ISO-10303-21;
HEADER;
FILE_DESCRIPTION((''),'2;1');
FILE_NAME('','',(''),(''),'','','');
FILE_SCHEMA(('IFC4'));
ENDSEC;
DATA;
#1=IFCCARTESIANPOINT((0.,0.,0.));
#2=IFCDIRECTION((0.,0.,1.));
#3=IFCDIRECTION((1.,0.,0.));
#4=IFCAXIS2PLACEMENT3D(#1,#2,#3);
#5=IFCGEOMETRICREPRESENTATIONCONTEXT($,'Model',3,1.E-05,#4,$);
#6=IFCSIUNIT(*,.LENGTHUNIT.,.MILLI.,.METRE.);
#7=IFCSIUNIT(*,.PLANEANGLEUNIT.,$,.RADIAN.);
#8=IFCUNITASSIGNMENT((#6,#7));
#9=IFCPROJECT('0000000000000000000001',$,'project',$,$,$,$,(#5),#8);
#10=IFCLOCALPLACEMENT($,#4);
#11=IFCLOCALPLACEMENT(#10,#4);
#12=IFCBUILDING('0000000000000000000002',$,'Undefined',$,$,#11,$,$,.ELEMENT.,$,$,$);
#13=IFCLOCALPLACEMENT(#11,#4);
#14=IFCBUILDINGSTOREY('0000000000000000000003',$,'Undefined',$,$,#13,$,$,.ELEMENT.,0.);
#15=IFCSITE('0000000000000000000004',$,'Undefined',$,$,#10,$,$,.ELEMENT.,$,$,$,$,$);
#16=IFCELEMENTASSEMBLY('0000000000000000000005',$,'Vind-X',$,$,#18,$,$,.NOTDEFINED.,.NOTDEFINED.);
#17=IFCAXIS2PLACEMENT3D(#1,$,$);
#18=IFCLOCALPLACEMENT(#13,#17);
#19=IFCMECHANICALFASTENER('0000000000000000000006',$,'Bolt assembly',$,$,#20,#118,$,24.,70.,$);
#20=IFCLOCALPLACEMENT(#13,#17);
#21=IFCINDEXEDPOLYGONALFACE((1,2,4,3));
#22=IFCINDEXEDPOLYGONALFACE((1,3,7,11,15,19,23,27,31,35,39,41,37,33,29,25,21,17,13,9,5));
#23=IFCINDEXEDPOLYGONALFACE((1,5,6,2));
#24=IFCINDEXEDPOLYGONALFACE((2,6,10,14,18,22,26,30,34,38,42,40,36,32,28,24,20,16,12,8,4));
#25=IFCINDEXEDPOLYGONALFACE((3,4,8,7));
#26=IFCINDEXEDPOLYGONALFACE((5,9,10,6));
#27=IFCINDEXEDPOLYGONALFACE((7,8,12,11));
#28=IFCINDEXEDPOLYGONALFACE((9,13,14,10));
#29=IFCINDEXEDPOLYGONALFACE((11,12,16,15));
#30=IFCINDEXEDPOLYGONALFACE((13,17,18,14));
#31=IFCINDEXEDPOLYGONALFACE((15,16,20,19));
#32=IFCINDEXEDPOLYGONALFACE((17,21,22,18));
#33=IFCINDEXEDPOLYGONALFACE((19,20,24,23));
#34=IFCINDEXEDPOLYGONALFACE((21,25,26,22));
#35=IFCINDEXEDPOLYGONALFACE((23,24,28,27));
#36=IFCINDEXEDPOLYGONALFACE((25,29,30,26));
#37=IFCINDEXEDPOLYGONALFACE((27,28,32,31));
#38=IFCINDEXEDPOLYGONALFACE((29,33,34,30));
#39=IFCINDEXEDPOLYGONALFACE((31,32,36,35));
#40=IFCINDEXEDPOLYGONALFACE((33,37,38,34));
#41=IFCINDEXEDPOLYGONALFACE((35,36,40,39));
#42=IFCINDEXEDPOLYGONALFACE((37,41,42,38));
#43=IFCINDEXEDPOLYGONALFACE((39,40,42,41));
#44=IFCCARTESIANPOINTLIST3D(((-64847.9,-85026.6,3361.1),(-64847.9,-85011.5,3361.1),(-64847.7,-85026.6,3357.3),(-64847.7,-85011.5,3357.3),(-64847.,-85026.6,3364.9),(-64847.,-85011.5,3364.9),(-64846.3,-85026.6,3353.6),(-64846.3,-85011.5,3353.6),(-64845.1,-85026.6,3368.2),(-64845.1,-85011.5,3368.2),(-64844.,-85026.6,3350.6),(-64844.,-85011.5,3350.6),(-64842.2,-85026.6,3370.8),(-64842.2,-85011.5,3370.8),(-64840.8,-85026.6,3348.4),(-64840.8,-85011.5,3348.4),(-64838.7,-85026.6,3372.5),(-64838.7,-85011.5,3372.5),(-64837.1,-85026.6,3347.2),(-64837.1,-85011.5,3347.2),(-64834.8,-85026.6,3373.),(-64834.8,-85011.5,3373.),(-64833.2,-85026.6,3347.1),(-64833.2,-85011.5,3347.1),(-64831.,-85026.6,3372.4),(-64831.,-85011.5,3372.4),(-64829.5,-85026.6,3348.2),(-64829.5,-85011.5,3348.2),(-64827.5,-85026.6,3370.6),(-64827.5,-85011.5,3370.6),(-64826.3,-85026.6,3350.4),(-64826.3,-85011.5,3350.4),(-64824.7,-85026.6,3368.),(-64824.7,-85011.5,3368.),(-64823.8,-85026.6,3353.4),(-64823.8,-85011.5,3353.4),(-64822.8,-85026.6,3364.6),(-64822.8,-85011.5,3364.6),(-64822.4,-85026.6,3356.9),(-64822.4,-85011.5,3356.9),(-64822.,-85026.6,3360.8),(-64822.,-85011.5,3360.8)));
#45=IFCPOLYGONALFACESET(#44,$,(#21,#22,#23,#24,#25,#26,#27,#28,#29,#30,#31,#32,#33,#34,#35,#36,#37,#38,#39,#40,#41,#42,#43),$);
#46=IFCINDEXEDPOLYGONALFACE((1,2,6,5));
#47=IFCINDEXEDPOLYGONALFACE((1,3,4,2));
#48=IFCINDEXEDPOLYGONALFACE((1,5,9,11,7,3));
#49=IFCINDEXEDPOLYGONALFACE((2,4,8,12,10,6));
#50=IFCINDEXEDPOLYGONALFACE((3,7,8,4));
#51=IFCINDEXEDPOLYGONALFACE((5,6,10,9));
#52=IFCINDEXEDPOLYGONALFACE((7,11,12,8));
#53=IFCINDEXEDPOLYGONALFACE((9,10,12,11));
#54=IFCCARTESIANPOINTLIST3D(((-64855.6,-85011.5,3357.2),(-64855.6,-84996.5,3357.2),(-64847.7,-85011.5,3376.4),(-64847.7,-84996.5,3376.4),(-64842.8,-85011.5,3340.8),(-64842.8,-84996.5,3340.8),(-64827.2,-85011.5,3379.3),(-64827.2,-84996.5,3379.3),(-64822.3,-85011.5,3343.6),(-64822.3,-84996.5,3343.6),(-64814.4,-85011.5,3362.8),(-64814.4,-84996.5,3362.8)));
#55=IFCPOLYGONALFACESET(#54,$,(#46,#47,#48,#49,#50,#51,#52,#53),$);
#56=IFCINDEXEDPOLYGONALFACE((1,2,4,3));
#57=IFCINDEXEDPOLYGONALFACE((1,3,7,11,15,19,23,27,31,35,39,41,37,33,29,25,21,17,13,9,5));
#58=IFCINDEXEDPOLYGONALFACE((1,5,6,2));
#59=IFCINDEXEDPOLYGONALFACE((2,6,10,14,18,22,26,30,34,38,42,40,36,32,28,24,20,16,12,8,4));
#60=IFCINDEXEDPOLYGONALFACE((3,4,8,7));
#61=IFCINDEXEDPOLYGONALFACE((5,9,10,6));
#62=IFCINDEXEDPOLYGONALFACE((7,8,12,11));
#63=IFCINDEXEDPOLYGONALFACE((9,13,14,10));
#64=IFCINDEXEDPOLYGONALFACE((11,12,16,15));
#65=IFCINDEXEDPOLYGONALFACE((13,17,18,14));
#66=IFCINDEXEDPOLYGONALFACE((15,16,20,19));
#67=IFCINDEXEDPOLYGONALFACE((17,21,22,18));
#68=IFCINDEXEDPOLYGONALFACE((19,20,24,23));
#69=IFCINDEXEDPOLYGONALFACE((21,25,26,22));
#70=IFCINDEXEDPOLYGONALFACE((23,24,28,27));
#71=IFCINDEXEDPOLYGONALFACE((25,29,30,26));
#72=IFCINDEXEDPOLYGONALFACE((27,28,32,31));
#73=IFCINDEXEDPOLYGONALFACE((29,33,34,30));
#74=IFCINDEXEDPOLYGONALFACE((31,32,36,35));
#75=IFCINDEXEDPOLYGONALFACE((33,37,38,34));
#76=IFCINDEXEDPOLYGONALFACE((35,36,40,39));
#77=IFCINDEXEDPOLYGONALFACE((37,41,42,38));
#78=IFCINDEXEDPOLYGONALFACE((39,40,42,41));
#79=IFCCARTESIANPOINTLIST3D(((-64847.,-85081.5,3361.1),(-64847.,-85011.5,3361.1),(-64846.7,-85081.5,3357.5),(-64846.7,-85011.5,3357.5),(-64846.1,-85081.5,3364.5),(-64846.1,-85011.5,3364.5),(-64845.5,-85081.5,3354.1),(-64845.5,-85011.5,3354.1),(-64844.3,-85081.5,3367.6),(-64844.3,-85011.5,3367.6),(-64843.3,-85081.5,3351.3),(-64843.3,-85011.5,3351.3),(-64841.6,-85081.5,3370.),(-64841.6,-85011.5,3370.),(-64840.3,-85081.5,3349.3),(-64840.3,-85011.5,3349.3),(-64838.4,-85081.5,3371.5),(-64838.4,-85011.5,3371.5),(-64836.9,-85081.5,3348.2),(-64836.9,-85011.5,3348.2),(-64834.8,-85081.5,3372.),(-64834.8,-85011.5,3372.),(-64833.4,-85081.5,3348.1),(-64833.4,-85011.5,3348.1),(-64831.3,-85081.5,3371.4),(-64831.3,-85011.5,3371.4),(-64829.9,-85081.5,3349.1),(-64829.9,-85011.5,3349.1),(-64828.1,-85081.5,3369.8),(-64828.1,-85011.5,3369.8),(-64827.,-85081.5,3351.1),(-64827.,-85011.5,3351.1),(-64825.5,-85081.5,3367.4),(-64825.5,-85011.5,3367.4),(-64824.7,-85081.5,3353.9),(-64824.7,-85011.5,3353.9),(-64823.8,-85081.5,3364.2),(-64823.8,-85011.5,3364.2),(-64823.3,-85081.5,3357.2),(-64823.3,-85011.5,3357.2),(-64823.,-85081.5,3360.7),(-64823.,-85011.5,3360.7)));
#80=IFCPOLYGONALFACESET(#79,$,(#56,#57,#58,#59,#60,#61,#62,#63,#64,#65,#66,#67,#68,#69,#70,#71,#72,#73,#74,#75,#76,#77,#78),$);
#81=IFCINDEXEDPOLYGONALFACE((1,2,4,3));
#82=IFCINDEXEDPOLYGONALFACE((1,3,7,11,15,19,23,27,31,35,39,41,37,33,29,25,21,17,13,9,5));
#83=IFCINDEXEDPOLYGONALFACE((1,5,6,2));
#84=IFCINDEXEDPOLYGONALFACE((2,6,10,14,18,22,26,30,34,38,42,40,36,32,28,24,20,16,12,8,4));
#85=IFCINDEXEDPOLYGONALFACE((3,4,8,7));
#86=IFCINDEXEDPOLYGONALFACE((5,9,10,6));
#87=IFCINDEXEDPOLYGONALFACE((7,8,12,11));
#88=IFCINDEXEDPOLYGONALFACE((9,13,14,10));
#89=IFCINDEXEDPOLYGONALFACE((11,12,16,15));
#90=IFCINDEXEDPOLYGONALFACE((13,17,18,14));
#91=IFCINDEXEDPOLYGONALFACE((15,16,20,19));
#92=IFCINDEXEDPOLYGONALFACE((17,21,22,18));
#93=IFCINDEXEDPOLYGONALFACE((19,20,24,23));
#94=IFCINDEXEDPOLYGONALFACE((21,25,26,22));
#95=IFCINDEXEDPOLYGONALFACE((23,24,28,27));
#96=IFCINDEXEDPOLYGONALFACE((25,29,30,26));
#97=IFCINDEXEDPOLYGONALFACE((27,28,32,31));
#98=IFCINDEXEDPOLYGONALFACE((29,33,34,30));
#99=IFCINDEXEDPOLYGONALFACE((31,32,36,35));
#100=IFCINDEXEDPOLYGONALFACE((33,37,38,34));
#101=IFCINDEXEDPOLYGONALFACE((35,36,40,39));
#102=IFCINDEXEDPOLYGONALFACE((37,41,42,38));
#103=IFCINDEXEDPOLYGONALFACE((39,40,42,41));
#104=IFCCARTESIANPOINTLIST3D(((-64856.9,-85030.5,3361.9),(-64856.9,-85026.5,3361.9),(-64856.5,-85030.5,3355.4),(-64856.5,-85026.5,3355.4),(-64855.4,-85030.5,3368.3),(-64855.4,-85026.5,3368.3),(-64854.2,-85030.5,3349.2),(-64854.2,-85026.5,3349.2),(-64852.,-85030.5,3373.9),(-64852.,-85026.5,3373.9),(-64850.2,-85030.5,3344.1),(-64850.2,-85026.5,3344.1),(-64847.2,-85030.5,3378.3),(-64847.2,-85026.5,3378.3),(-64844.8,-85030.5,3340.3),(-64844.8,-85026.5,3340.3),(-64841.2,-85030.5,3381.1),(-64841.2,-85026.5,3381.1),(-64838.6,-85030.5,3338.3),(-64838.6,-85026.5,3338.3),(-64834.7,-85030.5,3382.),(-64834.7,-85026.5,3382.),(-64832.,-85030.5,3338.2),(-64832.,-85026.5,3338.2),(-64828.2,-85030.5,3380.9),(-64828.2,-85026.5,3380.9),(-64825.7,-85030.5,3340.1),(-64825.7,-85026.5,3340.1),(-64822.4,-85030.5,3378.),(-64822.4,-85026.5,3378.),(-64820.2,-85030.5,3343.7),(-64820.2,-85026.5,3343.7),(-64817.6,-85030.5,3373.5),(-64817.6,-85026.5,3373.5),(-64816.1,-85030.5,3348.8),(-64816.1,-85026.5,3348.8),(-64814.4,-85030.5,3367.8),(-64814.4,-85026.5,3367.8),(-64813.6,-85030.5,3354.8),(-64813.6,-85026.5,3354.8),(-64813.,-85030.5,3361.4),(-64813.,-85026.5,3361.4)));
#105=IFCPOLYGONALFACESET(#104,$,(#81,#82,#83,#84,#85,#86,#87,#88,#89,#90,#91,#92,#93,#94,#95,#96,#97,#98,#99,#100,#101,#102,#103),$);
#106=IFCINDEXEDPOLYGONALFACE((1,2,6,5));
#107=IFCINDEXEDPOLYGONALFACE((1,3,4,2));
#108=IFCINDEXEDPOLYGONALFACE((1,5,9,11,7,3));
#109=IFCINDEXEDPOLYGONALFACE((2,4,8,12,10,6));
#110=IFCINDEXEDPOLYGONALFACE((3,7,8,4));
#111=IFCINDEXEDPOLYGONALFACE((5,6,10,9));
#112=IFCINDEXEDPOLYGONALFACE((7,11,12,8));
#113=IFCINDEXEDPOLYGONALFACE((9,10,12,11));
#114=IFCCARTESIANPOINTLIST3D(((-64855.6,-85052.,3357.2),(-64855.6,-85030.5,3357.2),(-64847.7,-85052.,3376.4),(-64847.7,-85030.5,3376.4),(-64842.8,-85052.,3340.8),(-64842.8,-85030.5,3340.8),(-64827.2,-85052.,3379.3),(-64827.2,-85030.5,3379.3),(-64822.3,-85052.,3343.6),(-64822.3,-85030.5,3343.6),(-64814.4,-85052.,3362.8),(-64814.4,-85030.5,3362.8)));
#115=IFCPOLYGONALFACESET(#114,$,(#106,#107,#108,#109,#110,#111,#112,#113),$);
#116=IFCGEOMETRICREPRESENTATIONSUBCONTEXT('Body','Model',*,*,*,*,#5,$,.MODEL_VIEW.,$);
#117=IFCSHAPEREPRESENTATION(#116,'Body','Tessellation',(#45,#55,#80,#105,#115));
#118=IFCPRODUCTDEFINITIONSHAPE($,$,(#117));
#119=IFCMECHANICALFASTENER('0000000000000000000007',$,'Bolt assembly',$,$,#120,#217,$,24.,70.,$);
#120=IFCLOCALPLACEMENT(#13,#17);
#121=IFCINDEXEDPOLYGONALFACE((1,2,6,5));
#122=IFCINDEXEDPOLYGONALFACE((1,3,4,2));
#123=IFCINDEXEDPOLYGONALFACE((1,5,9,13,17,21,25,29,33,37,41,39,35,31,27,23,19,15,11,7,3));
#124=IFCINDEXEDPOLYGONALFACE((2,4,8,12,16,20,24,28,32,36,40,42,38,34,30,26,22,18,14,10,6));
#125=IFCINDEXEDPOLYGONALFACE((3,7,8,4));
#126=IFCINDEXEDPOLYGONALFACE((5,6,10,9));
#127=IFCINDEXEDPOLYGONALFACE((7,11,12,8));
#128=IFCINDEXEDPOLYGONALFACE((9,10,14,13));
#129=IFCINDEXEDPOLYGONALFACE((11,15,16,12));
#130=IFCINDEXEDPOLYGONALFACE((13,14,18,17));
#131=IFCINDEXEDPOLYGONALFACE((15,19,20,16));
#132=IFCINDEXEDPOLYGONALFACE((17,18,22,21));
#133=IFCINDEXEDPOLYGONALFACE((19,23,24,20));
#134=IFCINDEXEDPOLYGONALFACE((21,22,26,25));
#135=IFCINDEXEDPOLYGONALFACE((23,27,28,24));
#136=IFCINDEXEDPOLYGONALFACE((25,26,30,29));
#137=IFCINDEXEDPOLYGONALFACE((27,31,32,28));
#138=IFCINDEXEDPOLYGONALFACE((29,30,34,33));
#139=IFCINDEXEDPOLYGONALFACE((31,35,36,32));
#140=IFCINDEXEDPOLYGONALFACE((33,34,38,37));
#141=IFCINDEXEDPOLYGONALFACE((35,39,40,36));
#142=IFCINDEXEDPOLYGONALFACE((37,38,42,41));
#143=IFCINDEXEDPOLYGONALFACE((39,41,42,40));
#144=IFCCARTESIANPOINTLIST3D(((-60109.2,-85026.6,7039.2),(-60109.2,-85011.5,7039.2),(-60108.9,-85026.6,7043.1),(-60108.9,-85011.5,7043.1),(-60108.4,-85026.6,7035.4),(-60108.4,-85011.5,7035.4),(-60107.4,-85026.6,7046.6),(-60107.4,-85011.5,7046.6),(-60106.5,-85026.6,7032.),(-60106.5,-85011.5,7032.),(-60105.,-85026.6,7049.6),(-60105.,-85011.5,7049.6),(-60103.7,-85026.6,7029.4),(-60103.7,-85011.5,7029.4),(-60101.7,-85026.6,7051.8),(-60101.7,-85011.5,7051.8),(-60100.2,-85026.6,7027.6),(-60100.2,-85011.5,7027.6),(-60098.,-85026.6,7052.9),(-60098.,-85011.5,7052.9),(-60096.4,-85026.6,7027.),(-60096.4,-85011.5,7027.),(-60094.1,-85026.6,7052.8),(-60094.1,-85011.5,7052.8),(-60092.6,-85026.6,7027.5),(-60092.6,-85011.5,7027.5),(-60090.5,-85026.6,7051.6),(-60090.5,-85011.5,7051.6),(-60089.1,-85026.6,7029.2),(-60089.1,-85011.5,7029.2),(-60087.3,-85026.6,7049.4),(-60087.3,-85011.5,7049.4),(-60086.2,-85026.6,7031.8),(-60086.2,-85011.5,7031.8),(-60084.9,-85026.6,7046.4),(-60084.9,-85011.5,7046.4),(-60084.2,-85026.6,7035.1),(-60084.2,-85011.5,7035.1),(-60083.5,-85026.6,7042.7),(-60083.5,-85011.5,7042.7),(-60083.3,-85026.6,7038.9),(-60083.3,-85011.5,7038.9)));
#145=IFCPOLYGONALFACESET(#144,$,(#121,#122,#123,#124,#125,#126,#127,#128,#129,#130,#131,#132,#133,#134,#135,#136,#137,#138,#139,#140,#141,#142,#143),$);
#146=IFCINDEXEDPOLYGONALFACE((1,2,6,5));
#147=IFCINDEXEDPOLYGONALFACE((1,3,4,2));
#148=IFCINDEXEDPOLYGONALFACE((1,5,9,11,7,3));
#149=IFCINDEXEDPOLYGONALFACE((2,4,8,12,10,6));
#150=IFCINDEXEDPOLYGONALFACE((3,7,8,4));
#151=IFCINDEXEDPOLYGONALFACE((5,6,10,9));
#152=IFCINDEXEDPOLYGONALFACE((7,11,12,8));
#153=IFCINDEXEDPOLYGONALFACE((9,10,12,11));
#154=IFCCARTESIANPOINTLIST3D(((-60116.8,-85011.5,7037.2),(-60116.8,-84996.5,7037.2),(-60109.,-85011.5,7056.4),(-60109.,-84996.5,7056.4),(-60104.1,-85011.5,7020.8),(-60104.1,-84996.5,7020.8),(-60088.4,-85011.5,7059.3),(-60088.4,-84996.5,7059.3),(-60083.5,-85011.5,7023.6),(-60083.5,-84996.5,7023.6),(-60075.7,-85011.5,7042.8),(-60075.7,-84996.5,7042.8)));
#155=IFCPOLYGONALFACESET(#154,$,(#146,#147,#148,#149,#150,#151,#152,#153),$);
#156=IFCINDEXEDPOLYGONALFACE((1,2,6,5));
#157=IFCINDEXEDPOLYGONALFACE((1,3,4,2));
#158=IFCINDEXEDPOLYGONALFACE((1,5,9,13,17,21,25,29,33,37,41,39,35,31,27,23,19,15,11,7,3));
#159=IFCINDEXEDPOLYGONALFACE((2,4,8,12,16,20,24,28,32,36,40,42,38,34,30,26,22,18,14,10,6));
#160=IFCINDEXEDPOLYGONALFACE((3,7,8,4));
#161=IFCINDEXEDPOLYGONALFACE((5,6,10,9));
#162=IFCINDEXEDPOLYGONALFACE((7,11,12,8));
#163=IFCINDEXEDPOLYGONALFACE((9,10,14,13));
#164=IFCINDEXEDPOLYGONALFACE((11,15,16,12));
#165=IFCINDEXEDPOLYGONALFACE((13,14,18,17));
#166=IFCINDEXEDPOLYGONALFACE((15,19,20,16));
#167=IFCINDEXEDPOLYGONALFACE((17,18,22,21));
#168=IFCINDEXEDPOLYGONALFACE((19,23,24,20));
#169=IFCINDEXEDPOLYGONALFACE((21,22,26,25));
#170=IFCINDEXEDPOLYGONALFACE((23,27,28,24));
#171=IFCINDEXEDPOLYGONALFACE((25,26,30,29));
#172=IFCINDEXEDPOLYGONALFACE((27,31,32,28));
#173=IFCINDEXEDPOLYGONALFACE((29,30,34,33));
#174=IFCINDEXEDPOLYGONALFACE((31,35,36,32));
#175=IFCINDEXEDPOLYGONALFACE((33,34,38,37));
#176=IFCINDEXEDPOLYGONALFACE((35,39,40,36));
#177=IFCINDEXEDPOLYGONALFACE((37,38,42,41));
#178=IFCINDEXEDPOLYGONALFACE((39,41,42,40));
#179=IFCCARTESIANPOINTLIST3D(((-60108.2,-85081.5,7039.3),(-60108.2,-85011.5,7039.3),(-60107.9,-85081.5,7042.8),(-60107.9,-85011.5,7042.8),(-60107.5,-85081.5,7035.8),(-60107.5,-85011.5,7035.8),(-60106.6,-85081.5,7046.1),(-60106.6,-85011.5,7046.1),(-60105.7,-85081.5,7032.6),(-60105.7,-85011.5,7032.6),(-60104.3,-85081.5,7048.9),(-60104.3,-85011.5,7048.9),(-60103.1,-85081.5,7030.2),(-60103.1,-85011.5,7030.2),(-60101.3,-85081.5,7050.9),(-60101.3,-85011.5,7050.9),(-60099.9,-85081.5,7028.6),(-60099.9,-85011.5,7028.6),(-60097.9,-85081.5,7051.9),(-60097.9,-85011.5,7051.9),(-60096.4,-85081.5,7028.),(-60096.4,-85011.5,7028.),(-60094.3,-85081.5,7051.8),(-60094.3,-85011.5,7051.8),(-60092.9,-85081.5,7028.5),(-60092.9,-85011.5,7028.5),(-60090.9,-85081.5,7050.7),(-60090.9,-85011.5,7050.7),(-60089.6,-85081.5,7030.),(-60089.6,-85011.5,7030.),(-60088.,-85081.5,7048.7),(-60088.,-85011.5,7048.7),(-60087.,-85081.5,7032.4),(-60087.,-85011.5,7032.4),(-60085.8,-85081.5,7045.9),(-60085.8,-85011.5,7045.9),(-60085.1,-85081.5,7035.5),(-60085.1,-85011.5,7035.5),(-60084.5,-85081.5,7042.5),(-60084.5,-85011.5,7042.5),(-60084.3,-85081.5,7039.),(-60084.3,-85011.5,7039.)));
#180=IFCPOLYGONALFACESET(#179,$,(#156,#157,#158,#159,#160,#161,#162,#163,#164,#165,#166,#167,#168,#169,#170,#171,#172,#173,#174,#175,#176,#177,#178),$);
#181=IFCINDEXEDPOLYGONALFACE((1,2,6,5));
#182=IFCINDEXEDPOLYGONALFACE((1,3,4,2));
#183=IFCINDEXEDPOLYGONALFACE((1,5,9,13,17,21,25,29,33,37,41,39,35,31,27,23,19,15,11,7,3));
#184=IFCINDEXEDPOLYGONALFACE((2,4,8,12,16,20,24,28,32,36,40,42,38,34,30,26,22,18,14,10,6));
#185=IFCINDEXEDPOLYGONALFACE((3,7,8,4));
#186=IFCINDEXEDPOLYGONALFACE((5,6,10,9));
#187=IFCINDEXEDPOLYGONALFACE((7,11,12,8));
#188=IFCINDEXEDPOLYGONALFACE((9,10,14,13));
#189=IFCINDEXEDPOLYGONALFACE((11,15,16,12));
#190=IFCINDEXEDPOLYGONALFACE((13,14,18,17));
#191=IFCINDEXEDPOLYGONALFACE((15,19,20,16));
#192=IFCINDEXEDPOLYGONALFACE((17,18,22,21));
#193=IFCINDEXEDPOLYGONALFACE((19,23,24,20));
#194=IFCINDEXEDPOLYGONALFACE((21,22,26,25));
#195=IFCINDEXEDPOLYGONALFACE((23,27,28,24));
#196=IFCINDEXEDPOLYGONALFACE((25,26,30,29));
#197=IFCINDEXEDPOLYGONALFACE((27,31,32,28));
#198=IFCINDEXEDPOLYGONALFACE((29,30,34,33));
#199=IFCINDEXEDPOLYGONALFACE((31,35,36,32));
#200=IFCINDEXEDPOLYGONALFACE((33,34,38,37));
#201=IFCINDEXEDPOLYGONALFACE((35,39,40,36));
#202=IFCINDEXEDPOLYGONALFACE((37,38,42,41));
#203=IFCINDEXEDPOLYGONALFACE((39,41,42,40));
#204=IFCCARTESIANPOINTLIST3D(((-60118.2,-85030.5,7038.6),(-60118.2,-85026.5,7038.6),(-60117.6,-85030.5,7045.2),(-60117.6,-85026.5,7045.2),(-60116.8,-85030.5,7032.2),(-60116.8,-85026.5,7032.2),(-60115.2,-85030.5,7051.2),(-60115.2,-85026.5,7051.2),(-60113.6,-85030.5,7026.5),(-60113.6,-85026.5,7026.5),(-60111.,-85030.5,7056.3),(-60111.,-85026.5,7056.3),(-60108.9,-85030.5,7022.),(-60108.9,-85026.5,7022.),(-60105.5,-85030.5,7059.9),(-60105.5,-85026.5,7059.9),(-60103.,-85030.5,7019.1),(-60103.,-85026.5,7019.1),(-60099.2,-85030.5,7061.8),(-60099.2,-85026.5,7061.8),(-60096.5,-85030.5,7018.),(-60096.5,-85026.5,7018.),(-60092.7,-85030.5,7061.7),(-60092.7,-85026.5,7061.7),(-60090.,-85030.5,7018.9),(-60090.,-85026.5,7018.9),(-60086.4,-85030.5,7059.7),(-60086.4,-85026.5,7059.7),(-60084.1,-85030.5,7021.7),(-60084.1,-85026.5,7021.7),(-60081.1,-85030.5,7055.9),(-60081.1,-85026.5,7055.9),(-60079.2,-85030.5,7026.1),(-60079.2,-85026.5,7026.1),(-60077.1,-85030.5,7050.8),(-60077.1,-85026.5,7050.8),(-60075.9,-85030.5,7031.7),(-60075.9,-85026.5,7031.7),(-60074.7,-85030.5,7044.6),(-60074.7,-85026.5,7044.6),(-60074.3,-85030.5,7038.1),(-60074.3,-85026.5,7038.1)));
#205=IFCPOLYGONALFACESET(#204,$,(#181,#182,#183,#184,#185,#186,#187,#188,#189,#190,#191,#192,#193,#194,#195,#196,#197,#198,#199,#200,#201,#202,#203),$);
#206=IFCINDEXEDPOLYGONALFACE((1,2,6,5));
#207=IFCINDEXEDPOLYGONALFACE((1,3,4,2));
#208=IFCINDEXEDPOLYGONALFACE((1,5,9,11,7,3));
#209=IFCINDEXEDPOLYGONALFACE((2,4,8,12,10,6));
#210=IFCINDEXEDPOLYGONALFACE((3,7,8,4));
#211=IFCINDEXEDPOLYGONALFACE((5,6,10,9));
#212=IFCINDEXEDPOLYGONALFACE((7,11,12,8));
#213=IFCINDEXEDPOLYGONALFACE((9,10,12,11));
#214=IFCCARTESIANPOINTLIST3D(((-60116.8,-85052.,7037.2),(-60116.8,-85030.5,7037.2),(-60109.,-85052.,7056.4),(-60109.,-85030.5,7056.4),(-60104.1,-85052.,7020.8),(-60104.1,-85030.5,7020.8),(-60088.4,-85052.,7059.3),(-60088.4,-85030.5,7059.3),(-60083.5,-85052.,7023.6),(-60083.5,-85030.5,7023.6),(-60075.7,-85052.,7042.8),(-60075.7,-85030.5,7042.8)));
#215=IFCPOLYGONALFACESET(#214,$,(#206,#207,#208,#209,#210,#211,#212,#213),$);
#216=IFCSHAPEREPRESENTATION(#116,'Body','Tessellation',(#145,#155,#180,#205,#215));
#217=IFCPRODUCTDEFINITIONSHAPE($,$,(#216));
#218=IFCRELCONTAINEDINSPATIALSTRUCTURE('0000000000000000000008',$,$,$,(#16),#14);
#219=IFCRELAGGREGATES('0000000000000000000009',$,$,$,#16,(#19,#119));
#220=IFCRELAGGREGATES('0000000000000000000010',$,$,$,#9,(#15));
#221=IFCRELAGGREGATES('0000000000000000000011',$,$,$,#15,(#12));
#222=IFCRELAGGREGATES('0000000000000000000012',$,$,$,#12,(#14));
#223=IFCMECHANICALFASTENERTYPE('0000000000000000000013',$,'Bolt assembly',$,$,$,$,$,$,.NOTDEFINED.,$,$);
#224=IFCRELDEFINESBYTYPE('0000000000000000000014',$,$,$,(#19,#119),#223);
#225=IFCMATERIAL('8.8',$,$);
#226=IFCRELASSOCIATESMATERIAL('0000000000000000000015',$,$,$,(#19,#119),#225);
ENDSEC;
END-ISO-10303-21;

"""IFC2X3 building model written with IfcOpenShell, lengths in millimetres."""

from ifc_helpers import new_model, si_unit, frame, origin_with_axes, origin_2d_with_axis, place, context, subcontext, project, spatial, polyline, circle, outline, extrude, source, transform, mapped, material, type_object, element, aggregate, save


model = new_model("IFC2X3")

# Units and contexts
model_context = context("Model", 3, precision=1e-05, world=origin_with_axes())
body_context = subcontext(model_context, "Body", "Model", "MODEL_VIEW")
ifc_project = project(units=[si_unit("LENGTHUNIT", "METRE", prefix="MILLI"), si_unit("PLANEANGLEUNIT", "RADIAN")], contexts=[model_context])

# Site, building, storey
site_placement = place(None, origin_with_axes())
site = spatial("IfcSite", under=ifc_project, at=site_placement, Name="Undefined", CompositionType="ELEMENT")
building_placement = place(site_placement, origin_with_axes())
building = spatial("IfcBuilding", under=site, at=building_placement, Name="Undefined", CompositionType="ELEMENT")
storey_placement = place(building_placement, origin_with_axes())
storey = spatial("IfcBuildingStorey", under=building, at=storey_placement, Name="Undefined", CompositionType="ELEMENT", Elevation=0.0)

# Element assembly
assembly_1_placement = place(storey_placement, origin_with_axes())
assembly_1 = element("IfcElementAssembly", 1, at=assembly_1_placement, inside=storey, Name="Vind-X", AssemblyPlace="NOTDEFINED", PredefinedType="NOTDEFINED")

# Mechanical fasteners
mechanical_fastener_type = type_object("IfcMechanicalFastenerType", Name="Bolt assembly")
ifc_material_1 = material(Name="8.8")
shared_shape_1 = source(origin_with_axes(), body_context, "Body", "SweptSolid", [
    extrude(circle(Radius=13.0, at=origin_2d_with_axis()), frame((0.0, 0.0, 0.0), z_axis=(0.0, 1.0, 0.0), x_axis=(1.0, 0.0, 0.0)), (0.0, 0.0, 1.0), 15.1),
    extrude(outline(polyline([(18.0, -10.4), (18.0, 10.4), (0.0, 20.8), (-18.0, 10.4), (-18.0, -10.4), (0.0, -20.8), (18.0, -10.4)])), frame((0.0, -15.0, 0.0), z_axis=(0.0, 1.0, 0.0), x_axis=(1.0, 0.0, 0.0)), (0.0, 0.0, 1.0), 15.0),
    extrude(circle(Radius=12.0, at=origin_2d_with_axis()), frame((0.0, 0.0, 0.0), z_axis=(0.0, 1.0, 0.0), x_axis=(1.0, 0.0, 0.0)), (0.0, 0.0, 1.0), 70.0),
    extrude(circle(Radius=22.0, at=origin_2d_with_axis()), frame((0.0, 15.0, 0.0), z_axis=(0.0, 1.0, 0.0), x_axis=(1.0, 0.0, 0.0)), (0.0, 0.0, 1.0), 4.0),
    extrude(outline(polyline([(18.0, -10.4), (18.0, 10.4), (0.0, 20.8), (-18.0, 10.4), (-18.0, -10.4), (0.0, -20.8), (18.0, -10.4)])), frame((0.0, 19.0, 0.0), z_axis=(0.0, 1.0, 0.0), x_axis=(1.0, 0.0, 0.0)), (0.0, 0.0, 1.0), 21.5),
])
mechanical_fastener_1_placement = place(assembly_1_placement, frame((-64835.0, -85011.5, 3360.0), z_axis=(0.613349, 0.0, -0.789812), x_axis=(0.789812, 0.0, 0.613349)))
mechanical_fastener_1 = element("IfcMechanicalFastener", 2, at=mechanical_fastener_1_placement, type_object=mechanical_fastener_type, material=ifc_material_1, Name="Bolt assembly", NominalDiameter=24.0, NominalLength=70.0, context=body_context, shape_type="MappedRepresentation", body=[
    mapped(shared_shape_1, transform((0.0, 0.0, 0.0))),
])
mechanical_fastener_2_placement = place(assembly_1_placement, frame((-60096.2, -85011.5, 7040.0), z_axis=(-0.613349, 0.0, 0.789812), x_axis=(-0.789812, 0.0, -0.613349)))
mechanical_fastener_2 = element("IfcMechanicalFastener", 3, at=mechanical_fastener_2_placement, type_object=mechanical_fastener_type, material=ifc_material_1, Name="Bolt assembly", NominalDiameter=24.0, NominalLength=70.0, context=body_context, shape_type="MappedRepresentation", body=[
    mapped(shared_shape_1, transform((0.0, 0.0, 0.0))),
])
aggregate(assembly_1, [mechanical_fastener_1, mechanical_fastener_2])

save(model, "model.ifc")
